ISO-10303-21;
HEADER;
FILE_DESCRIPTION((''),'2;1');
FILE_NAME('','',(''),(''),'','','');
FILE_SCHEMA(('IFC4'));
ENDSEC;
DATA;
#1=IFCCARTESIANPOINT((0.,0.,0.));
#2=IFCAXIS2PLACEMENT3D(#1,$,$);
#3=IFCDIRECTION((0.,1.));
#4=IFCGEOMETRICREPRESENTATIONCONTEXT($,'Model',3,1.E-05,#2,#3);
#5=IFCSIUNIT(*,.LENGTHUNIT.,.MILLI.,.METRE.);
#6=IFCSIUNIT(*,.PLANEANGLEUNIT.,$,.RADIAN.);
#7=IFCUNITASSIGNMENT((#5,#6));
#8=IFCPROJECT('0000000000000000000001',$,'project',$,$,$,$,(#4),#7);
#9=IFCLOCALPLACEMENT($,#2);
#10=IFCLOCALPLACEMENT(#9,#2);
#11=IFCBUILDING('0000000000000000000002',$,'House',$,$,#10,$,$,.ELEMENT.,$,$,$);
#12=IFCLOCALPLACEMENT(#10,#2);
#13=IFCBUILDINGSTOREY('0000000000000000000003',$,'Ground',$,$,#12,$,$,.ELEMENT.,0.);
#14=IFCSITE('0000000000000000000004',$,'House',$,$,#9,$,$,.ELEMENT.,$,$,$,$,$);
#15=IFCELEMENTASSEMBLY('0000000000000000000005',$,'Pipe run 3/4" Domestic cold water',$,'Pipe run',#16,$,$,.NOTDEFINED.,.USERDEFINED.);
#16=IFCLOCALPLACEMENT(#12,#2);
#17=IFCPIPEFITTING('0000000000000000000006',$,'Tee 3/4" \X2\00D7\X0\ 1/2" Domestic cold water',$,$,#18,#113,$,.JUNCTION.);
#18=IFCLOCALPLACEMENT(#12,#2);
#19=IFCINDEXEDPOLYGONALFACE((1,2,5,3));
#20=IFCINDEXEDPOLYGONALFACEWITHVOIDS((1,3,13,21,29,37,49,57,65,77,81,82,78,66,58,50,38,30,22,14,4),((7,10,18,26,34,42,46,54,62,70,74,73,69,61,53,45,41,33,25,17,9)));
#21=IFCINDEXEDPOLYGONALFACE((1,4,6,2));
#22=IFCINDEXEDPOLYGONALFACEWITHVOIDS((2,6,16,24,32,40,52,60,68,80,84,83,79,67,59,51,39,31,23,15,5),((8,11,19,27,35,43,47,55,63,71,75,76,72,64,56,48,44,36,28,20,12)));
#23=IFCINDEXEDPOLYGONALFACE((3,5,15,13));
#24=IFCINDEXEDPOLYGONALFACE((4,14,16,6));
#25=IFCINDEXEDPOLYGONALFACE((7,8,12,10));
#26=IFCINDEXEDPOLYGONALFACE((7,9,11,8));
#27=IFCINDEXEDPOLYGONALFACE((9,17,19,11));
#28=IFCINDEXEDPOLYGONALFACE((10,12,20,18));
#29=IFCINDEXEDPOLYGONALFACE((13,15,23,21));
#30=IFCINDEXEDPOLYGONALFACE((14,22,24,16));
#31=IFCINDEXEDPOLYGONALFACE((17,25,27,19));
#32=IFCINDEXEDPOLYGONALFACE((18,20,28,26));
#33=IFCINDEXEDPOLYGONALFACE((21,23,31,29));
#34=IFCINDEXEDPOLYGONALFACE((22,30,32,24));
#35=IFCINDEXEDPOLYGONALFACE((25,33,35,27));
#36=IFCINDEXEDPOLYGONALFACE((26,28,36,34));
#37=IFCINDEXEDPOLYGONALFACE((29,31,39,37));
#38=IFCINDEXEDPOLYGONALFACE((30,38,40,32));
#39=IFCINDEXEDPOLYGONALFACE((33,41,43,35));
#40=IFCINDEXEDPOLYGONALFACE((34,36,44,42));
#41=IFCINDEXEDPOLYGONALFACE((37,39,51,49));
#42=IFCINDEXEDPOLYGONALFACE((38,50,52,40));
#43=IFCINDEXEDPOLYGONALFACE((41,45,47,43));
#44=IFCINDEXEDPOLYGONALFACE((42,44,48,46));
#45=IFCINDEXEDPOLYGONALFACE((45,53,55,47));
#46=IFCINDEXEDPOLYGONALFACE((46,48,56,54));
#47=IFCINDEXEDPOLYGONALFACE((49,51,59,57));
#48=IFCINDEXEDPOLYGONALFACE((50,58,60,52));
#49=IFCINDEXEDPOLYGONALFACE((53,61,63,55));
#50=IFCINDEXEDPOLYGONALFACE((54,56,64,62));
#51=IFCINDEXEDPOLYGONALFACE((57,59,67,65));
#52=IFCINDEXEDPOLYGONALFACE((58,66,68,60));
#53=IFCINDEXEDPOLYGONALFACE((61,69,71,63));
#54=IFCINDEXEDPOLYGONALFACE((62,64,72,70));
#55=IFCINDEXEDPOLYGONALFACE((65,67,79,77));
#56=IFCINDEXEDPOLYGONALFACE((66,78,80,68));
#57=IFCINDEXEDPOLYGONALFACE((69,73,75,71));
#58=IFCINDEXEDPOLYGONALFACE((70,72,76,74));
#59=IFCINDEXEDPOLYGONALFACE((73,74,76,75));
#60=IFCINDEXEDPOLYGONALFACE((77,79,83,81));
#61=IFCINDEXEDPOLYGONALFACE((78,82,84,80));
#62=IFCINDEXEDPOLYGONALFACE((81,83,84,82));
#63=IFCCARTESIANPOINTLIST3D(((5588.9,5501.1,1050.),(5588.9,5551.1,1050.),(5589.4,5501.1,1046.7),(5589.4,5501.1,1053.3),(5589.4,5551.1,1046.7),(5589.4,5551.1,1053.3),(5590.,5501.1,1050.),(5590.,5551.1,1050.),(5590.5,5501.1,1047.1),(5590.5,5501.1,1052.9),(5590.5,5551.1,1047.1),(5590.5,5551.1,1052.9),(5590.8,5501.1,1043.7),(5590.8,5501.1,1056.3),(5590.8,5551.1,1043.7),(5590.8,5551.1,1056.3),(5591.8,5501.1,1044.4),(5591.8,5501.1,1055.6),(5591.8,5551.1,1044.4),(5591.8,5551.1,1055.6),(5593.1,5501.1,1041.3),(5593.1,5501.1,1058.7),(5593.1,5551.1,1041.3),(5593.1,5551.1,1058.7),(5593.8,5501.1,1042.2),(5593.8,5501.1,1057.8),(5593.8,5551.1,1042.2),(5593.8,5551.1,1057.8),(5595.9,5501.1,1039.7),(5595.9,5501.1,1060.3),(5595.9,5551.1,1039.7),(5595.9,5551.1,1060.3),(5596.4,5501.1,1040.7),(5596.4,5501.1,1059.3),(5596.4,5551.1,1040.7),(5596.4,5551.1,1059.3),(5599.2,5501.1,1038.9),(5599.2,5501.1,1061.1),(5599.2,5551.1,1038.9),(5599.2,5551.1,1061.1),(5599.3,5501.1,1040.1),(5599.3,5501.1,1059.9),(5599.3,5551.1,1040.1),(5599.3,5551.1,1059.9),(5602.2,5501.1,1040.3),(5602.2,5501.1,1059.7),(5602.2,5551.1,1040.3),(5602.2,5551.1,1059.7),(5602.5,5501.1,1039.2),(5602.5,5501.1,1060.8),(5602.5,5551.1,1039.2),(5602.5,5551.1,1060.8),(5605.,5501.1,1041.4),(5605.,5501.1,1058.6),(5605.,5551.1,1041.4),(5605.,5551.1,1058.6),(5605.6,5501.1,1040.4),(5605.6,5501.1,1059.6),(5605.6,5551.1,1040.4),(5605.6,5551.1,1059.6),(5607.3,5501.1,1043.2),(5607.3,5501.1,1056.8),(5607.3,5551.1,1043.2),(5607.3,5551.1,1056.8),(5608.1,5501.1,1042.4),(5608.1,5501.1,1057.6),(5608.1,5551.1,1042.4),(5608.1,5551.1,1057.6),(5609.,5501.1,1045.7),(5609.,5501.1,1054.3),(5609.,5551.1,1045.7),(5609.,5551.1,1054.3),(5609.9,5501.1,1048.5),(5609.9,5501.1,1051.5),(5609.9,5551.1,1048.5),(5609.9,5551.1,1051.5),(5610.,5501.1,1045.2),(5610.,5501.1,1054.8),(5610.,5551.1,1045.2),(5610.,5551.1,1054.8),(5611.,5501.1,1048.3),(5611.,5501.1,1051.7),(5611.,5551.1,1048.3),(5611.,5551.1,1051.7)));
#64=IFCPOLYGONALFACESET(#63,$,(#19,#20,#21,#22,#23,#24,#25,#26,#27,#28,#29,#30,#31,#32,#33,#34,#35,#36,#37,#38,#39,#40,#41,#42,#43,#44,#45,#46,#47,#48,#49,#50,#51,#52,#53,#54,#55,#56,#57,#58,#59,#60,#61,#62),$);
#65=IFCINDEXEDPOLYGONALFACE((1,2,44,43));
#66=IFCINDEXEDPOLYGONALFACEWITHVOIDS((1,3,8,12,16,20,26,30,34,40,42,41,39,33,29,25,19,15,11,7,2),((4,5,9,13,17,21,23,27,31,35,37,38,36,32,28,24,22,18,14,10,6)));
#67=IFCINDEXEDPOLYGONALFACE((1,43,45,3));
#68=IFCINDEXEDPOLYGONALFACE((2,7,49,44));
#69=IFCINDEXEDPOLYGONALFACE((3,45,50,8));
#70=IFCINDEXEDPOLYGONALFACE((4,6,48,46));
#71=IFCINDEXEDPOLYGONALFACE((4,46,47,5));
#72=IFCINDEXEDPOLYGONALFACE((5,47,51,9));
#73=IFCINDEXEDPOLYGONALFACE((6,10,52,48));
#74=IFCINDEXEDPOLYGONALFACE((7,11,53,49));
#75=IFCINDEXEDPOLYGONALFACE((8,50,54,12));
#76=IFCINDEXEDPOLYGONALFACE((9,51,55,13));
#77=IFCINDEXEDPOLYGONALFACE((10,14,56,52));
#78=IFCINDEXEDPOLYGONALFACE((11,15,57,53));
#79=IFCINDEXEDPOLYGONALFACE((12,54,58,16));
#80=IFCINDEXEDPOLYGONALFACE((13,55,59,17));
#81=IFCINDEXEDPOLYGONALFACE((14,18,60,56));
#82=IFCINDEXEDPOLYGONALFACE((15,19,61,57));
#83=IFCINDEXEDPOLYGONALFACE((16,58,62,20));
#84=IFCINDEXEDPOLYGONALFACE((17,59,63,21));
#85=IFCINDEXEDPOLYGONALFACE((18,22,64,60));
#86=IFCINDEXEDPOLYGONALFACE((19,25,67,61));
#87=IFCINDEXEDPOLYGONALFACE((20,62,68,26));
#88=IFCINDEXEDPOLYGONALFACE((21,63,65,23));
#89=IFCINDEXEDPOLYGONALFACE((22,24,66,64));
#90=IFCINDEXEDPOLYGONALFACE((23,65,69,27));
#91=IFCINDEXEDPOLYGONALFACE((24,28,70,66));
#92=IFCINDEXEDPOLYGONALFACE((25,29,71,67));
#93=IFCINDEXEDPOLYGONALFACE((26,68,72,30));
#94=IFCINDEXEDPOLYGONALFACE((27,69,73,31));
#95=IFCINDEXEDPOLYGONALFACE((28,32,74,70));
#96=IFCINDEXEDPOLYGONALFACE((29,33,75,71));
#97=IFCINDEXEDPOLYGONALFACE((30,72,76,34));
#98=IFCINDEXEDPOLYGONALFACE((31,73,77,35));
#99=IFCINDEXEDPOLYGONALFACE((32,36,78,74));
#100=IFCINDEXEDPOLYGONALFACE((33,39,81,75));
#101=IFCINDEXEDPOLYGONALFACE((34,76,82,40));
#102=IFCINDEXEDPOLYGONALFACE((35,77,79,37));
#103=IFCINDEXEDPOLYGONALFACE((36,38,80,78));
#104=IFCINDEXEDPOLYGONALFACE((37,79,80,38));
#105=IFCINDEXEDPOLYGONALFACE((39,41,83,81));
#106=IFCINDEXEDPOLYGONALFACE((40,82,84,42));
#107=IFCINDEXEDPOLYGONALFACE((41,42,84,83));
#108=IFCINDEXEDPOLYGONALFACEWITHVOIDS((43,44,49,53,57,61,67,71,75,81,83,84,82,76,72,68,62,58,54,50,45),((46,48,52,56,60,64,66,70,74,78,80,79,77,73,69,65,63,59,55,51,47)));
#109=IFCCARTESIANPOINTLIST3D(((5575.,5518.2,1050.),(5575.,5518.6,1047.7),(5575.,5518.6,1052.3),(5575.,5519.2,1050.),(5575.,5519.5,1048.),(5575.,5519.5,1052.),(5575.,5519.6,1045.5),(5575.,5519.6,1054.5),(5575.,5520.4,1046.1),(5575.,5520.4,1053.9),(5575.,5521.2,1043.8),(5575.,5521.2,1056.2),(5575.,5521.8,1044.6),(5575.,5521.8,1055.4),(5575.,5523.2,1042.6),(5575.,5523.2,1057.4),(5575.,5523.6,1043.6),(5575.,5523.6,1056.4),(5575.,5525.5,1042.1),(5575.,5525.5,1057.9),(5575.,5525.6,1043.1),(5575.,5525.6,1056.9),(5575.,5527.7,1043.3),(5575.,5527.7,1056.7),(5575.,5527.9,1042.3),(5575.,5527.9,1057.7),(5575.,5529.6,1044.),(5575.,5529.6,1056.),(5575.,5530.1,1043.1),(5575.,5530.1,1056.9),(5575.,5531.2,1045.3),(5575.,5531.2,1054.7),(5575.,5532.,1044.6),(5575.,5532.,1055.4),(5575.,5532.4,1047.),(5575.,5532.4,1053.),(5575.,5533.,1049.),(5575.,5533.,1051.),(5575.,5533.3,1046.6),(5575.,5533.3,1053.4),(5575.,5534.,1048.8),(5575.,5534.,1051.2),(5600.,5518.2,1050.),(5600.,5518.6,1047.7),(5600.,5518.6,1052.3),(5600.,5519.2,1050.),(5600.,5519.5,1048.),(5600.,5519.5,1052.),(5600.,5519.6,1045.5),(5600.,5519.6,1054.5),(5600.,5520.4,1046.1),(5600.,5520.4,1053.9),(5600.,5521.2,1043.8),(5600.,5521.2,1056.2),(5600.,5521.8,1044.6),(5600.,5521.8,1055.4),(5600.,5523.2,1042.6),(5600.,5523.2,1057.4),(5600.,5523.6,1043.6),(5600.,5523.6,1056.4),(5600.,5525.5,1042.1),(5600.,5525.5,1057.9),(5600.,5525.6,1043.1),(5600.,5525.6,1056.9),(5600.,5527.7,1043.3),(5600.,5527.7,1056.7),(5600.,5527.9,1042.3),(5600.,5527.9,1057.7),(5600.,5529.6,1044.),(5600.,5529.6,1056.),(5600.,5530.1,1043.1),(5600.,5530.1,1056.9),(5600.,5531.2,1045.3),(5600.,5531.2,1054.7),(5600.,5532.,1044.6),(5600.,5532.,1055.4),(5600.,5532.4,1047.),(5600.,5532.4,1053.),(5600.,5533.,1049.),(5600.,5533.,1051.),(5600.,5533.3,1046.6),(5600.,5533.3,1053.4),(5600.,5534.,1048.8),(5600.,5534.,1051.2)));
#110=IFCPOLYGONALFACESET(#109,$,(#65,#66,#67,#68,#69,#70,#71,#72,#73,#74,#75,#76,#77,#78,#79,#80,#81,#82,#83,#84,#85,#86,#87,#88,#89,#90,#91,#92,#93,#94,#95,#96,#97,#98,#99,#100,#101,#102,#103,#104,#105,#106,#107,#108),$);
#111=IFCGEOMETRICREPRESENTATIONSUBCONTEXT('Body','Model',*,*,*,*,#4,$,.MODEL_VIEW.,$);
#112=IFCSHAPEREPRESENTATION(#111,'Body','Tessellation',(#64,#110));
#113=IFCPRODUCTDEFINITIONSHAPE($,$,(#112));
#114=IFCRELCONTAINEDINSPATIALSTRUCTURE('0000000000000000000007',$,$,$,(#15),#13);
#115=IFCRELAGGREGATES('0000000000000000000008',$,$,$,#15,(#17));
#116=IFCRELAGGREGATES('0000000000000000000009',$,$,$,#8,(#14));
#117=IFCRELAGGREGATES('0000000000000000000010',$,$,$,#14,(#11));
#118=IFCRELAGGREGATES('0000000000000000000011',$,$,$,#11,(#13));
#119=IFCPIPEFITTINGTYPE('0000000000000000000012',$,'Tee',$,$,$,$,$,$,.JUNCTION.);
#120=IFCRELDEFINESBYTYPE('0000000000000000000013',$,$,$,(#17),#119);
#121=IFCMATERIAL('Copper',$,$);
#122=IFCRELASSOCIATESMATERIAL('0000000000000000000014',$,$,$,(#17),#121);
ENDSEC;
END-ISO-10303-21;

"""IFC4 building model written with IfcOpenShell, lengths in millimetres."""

from ifc_helpers import new_model, si_unit, direction, frame, origin, origin_with_axes, origin_2d, place, context, subcontext, project, spatial, hollow_circle, extrude, material, type_object, element, aggregate, save


model = new_model("IFC4")

# Units and contexts
model_context = context("Model", 3, precision=1e-05, world=origin(), true_north=direction((0.0, 1.0)))
body_context = subcontext(model_context, "Body", "Model", "MODEL_VIEW")
ifc_project = project(units=[si_unit("LENGTHUNIT", "METRE", prefix="MILLI"), si_unit("PLANEANGLEUNIT", "RADIAN")], contexts=[model_context])

# Site, building, storey
site_placement = place(None, origin())
site = spatial("IfcSite", under=ifc_project, at=site_placement, Name="House", CompositionType="ELEMENT")
building_placement = place(site_placement, origin())
building = spatial("IfcBuilding", under=site, at=building_placement, Name="House", CompositionType="ELEMENT")
storey_placement = place(building_placement, origin())
storey = spatial("IfcBuildingStorey", under=building, at=storey_placement, Name="Ground", CompositionType="ELEMENT", Elevation=0.0)

# Element assembly
ifc_material = material(Name="Copper")
assembly_1_placement = place(storey_placement, origin_with_axes())
assembly_1 = element("IfcElementAssembly", 1, at=assembly_1_placement, inside=storey, Name="Pipe run 3/4\" Domestic cold water", ObjectType="Pipe run", AssemblyPlace="NOTDEFINED", PredefinedType="USERDEFINED")

# Pipe fitting
pipe_fitting_type_1 = type_object("IfcPipeFittingType", Name="Tee", PredefinedType="JUNCTION")
pipe_fitting_1_placement = place(storey_placement, origin_with_axes())
pipe_fitting_1 = element("IfcPipeFitting", 2, at=pipe_fitting_1_placement, type_object=pipe_fitting_type_1, material=ifc_material, Name="Tee 3/4\" × 1/2\" Domestic cold water", PredefinedType="JUNCTION", context=body_context, shape_type="SweptSolid", body=[
    extrude(hollow_circle(Radius=11.1, WallThickness=1.1, at=origin_2d()), frame((5600.0, 5501.1, 1050.0), z_axis=(0.0, 1.0, 0.0), x_axis=(-1.0, 0.0, 0.0)), (0.0, 0.0, 1.0), 50.0),
    extrude(hollow_circle(Radius=7.9, WallThickness=1.0, at=origin_2d()), frame((5600.0, 5526.1, 1050.0), z_axis=(-1.0, 0.0, 0.0), x_axis=(0.0, -1.0, 0.0)), (0.0, 0.0, 1.0), 25.0),
])
aggregate(assembly_1, [pipe_fitting_1])

save(model, "model.ifc")
